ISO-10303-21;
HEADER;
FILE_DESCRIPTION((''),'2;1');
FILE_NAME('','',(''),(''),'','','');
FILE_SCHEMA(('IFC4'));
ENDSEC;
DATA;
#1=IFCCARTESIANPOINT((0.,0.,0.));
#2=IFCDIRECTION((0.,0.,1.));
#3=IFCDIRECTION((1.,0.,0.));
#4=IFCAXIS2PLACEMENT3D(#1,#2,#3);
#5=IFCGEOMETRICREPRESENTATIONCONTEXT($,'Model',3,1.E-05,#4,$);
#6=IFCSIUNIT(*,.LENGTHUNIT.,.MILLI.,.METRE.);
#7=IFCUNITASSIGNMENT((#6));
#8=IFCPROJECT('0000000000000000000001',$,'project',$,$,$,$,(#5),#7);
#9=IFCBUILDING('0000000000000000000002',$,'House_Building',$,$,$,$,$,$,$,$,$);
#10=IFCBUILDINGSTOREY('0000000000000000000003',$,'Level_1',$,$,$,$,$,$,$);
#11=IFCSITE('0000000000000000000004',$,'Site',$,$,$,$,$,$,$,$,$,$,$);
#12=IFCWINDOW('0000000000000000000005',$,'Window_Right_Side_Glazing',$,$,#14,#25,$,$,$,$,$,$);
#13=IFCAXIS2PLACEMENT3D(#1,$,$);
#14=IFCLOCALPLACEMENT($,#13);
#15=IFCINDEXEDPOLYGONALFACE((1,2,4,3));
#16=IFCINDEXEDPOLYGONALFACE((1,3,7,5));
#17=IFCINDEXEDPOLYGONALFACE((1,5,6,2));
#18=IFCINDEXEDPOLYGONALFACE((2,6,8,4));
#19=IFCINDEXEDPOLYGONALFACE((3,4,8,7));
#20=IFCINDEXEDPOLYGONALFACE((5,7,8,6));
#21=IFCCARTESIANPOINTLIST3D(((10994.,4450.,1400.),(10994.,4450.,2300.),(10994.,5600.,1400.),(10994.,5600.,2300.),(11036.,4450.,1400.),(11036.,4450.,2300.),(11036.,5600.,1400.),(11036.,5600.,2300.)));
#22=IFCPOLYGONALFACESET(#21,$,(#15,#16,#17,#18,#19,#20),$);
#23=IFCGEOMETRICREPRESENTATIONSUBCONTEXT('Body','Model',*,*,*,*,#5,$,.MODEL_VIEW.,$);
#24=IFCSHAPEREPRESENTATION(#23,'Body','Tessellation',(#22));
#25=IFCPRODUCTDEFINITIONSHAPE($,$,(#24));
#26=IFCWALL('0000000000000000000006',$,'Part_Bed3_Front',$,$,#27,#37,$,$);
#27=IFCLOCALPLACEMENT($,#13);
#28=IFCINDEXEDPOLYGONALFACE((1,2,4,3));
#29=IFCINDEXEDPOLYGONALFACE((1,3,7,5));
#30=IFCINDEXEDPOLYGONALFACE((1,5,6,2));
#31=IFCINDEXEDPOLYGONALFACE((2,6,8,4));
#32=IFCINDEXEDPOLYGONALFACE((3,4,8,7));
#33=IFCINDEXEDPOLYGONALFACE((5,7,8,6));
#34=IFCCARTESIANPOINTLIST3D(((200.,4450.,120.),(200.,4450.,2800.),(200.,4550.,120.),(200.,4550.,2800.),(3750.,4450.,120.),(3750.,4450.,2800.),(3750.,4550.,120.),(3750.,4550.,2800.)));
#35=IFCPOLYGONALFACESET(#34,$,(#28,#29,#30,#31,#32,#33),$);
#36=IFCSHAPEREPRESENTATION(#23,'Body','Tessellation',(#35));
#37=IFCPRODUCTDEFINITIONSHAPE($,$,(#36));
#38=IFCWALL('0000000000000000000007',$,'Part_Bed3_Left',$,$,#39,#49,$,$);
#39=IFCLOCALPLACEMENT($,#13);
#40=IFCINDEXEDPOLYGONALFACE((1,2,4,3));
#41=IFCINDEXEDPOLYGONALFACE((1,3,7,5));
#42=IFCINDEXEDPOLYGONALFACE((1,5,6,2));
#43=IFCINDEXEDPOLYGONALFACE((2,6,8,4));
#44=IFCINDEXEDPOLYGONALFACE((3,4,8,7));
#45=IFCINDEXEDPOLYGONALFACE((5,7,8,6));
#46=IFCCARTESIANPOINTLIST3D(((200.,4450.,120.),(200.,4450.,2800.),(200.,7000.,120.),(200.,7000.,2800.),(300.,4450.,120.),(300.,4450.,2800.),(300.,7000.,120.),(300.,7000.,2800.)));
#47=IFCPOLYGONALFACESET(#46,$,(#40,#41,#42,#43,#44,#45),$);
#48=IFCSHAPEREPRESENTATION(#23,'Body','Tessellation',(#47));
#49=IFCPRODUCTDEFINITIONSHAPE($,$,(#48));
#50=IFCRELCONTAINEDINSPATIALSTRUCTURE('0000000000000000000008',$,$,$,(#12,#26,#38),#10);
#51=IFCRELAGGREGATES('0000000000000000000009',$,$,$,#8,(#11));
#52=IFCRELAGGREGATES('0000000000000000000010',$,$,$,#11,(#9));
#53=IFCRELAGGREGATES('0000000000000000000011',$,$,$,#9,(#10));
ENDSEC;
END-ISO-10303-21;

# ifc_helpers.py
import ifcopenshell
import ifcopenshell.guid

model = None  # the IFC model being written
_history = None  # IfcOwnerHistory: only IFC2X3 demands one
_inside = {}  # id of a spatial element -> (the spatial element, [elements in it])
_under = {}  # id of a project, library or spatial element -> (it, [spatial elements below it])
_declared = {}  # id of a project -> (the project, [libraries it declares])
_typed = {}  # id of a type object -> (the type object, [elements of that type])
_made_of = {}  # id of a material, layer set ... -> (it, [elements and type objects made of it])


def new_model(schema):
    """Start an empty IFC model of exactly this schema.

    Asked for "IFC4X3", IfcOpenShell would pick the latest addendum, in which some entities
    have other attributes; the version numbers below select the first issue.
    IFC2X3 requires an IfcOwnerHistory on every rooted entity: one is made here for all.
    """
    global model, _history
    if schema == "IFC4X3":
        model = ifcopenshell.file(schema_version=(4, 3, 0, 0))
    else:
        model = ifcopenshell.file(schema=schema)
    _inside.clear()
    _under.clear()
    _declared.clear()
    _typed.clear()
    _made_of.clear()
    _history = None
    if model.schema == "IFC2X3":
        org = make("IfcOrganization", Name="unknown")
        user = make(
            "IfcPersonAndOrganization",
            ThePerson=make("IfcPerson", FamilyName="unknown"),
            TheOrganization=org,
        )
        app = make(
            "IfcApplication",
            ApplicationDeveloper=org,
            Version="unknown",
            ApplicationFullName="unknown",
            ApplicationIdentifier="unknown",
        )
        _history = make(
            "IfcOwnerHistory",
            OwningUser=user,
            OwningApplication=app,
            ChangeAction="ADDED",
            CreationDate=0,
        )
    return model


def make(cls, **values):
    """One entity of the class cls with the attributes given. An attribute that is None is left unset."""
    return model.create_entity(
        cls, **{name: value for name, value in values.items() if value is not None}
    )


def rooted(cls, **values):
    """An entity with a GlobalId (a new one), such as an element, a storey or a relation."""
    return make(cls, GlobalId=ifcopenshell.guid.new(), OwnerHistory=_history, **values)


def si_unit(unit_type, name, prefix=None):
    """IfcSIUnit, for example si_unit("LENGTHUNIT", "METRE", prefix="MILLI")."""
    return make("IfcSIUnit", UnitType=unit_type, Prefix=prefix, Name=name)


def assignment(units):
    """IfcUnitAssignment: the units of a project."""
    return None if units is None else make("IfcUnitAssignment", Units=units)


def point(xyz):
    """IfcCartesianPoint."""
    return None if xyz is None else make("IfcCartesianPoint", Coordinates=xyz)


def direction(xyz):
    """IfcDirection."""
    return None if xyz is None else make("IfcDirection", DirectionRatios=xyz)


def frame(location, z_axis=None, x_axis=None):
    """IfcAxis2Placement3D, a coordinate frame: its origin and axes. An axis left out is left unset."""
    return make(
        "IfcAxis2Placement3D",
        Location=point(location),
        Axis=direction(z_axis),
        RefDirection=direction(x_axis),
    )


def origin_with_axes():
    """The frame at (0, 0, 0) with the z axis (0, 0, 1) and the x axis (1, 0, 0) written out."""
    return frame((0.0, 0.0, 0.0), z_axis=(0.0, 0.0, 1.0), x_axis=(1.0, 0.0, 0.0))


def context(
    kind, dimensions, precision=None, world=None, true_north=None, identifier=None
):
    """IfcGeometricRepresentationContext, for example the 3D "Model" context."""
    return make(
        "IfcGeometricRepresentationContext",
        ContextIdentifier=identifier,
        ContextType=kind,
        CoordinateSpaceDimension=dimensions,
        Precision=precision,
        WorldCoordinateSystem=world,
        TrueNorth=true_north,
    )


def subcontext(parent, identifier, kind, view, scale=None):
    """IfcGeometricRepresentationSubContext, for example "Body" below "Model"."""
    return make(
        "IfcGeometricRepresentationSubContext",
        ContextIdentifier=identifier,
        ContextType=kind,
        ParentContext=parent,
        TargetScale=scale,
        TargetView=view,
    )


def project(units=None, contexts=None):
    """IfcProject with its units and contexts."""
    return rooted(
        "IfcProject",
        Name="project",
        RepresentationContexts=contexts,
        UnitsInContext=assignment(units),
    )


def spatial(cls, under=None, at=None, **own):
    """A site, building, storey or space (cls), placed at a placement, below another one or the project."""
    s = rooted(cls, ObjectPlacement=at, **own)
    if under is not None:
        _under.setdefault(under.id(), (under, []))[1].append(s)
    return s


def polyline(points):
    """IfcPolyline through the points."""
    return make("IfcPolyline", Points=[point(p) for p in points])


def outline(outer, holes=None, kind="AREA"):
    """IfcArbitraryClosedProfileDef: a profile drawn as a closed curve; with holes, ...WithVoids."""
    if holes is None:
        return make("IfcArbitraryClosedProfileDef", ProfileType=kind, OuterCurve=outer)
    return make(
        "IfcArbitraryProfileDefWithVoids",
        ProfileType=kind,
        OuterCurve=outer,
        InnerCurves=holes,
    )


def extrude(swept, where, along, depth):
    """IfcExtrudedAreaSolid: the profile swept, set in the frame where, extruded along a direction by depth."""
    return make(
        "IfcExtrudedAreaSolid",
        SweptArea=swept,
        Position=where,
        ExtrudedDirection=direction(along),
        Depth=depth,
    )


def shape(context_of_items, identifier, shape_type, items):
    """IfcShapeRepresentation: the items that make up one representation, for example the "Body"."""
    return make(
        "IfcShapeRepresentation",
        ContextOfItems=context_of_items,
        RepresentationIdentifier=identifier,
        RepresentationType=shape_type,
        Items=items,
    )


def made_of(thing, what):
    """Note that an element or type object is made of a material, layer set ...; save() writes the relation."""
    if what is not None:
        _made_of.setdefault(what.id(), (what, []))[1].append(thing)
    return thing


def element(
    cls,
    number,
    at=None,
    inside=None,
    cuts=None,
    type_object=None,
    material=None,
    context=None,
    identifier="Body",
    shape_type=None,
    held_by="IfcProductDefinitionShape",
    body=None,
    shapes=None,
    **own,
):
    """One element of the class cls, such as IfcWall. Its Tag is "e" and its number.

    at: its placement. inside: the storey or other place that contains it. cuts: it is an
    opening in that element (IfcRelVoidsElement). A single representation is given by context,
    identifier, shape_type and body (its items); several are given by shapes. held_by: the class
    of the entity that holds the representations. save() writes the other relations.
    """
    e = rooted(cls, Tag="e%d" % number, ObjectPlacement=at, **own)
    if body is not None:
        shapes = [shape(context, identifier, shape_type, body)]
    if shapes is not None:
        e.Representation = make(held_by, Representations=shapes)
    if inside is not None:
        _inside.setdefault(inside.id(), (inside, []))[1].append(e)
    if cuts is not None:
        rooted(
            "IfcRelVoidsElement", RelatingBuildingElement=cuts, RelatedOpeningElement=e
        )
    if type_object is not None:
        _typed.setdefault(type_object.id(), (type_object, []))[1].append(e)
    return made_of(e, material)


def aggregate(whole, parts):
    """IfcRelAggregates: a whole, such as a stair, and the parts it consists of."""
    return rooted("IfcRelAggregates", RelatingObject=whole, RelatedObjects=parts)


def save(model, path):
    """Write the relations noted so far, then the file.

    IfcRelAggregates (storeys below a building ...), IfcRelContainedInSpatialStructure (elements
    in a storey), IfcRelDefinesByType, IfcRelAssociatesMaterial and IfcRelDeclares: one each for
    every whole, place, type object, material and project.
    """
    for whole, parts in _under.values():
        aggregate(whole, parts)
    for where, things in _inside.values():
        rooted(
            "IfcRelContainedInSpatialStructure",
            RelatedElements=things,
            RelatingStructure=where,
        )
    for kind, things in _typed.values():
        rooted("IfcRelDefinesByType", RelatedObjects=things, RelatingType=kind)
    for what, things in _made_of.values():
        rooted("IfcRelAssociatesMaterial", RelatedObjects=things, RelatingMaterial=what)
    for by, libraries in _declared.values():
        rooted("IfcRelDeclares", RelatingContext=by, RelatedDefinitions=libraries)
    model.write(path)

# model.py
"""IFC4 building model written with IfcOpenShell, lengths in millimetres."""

from ifc_helpers import new_model, si_unit, frame, origin_with_axes, context, subcontext, project, spatial, polyline, outline, extrude, element, save


model = new_model("IFC4")

# Units and contexts
model_context = context("Model", 3, precision=1e-05, world=origin_with_axes())
body_context = subcontext(model_context, "Body", "Model", "MODEL_VIEW")
ifc_project = project(units=[si_unit("LENGTHUNIT", "METRE", prefix="MILLI")], contexts=[model_context])

# Site, building, storey
site = spatial("IfcSite", under=ifc_project, Name="Site")
building = spatial("IfcBuilding", under=site, Name="House_Building")
storey = spatial("IfcBuildingStorey", under=building, Name="Level_1")

# Window
element("IfcWindow", 1, inside=storey, Name="Window_Right_Side_Glazing", context=body_context, shape_type="SweptSolid", body=[
    extrude(outline(polyline([(10994.0, 4450.0), (11036.0, 4450.0), (11036.0, 5600.0), (10994.0, 5600.0), (10994.0, 4450.0)])), frame((0.0, 0.0, 1400.0), z_axis=(0.0, 0.0, 1.0), x_axis=(1.0, 0.0, 0.0)), (0.0, 0.0, 1.0), 900.0),
])

# Walls
element("IfcWall", 2, inside=storey, Name="Part_Bed3_Front", context=body_context, shape_type="SweptSolid", body=[
    extrude(outline(polyline([(200.0, 4450.0), (3750.0, 4450.0), (3750.0, 4550.0), (200.0, 4550.0), (200.0, 4450.0)])), frame((0.0, 0.0, 120.0), z_axis=(0.0, 0.0, 1.0), x_axis=(1.0, 0.0, 0.0)), (0.0, 0.0, 1.0), 2680.0),
])
element("IfcWall", 3, inside=storey, Name="Part_Bed3_Left", context=body_context, shape_type="SweptSolid", body=[
    extrude(outline(polyline([(200.0, 4450.0), (300.0, 4450.0), (300.0, 7000.0), (200.0, 7000.0), (200.0, 4450.0)])), frame((0.0, 0.0, 120.0), z_axis=(0.0, 0.0, 1.0), x_axis=(1.0, 0.0, 0.0)), (0.0, 0.0, 1.0), 2680.0),
])

save(model, "model.ifc")
